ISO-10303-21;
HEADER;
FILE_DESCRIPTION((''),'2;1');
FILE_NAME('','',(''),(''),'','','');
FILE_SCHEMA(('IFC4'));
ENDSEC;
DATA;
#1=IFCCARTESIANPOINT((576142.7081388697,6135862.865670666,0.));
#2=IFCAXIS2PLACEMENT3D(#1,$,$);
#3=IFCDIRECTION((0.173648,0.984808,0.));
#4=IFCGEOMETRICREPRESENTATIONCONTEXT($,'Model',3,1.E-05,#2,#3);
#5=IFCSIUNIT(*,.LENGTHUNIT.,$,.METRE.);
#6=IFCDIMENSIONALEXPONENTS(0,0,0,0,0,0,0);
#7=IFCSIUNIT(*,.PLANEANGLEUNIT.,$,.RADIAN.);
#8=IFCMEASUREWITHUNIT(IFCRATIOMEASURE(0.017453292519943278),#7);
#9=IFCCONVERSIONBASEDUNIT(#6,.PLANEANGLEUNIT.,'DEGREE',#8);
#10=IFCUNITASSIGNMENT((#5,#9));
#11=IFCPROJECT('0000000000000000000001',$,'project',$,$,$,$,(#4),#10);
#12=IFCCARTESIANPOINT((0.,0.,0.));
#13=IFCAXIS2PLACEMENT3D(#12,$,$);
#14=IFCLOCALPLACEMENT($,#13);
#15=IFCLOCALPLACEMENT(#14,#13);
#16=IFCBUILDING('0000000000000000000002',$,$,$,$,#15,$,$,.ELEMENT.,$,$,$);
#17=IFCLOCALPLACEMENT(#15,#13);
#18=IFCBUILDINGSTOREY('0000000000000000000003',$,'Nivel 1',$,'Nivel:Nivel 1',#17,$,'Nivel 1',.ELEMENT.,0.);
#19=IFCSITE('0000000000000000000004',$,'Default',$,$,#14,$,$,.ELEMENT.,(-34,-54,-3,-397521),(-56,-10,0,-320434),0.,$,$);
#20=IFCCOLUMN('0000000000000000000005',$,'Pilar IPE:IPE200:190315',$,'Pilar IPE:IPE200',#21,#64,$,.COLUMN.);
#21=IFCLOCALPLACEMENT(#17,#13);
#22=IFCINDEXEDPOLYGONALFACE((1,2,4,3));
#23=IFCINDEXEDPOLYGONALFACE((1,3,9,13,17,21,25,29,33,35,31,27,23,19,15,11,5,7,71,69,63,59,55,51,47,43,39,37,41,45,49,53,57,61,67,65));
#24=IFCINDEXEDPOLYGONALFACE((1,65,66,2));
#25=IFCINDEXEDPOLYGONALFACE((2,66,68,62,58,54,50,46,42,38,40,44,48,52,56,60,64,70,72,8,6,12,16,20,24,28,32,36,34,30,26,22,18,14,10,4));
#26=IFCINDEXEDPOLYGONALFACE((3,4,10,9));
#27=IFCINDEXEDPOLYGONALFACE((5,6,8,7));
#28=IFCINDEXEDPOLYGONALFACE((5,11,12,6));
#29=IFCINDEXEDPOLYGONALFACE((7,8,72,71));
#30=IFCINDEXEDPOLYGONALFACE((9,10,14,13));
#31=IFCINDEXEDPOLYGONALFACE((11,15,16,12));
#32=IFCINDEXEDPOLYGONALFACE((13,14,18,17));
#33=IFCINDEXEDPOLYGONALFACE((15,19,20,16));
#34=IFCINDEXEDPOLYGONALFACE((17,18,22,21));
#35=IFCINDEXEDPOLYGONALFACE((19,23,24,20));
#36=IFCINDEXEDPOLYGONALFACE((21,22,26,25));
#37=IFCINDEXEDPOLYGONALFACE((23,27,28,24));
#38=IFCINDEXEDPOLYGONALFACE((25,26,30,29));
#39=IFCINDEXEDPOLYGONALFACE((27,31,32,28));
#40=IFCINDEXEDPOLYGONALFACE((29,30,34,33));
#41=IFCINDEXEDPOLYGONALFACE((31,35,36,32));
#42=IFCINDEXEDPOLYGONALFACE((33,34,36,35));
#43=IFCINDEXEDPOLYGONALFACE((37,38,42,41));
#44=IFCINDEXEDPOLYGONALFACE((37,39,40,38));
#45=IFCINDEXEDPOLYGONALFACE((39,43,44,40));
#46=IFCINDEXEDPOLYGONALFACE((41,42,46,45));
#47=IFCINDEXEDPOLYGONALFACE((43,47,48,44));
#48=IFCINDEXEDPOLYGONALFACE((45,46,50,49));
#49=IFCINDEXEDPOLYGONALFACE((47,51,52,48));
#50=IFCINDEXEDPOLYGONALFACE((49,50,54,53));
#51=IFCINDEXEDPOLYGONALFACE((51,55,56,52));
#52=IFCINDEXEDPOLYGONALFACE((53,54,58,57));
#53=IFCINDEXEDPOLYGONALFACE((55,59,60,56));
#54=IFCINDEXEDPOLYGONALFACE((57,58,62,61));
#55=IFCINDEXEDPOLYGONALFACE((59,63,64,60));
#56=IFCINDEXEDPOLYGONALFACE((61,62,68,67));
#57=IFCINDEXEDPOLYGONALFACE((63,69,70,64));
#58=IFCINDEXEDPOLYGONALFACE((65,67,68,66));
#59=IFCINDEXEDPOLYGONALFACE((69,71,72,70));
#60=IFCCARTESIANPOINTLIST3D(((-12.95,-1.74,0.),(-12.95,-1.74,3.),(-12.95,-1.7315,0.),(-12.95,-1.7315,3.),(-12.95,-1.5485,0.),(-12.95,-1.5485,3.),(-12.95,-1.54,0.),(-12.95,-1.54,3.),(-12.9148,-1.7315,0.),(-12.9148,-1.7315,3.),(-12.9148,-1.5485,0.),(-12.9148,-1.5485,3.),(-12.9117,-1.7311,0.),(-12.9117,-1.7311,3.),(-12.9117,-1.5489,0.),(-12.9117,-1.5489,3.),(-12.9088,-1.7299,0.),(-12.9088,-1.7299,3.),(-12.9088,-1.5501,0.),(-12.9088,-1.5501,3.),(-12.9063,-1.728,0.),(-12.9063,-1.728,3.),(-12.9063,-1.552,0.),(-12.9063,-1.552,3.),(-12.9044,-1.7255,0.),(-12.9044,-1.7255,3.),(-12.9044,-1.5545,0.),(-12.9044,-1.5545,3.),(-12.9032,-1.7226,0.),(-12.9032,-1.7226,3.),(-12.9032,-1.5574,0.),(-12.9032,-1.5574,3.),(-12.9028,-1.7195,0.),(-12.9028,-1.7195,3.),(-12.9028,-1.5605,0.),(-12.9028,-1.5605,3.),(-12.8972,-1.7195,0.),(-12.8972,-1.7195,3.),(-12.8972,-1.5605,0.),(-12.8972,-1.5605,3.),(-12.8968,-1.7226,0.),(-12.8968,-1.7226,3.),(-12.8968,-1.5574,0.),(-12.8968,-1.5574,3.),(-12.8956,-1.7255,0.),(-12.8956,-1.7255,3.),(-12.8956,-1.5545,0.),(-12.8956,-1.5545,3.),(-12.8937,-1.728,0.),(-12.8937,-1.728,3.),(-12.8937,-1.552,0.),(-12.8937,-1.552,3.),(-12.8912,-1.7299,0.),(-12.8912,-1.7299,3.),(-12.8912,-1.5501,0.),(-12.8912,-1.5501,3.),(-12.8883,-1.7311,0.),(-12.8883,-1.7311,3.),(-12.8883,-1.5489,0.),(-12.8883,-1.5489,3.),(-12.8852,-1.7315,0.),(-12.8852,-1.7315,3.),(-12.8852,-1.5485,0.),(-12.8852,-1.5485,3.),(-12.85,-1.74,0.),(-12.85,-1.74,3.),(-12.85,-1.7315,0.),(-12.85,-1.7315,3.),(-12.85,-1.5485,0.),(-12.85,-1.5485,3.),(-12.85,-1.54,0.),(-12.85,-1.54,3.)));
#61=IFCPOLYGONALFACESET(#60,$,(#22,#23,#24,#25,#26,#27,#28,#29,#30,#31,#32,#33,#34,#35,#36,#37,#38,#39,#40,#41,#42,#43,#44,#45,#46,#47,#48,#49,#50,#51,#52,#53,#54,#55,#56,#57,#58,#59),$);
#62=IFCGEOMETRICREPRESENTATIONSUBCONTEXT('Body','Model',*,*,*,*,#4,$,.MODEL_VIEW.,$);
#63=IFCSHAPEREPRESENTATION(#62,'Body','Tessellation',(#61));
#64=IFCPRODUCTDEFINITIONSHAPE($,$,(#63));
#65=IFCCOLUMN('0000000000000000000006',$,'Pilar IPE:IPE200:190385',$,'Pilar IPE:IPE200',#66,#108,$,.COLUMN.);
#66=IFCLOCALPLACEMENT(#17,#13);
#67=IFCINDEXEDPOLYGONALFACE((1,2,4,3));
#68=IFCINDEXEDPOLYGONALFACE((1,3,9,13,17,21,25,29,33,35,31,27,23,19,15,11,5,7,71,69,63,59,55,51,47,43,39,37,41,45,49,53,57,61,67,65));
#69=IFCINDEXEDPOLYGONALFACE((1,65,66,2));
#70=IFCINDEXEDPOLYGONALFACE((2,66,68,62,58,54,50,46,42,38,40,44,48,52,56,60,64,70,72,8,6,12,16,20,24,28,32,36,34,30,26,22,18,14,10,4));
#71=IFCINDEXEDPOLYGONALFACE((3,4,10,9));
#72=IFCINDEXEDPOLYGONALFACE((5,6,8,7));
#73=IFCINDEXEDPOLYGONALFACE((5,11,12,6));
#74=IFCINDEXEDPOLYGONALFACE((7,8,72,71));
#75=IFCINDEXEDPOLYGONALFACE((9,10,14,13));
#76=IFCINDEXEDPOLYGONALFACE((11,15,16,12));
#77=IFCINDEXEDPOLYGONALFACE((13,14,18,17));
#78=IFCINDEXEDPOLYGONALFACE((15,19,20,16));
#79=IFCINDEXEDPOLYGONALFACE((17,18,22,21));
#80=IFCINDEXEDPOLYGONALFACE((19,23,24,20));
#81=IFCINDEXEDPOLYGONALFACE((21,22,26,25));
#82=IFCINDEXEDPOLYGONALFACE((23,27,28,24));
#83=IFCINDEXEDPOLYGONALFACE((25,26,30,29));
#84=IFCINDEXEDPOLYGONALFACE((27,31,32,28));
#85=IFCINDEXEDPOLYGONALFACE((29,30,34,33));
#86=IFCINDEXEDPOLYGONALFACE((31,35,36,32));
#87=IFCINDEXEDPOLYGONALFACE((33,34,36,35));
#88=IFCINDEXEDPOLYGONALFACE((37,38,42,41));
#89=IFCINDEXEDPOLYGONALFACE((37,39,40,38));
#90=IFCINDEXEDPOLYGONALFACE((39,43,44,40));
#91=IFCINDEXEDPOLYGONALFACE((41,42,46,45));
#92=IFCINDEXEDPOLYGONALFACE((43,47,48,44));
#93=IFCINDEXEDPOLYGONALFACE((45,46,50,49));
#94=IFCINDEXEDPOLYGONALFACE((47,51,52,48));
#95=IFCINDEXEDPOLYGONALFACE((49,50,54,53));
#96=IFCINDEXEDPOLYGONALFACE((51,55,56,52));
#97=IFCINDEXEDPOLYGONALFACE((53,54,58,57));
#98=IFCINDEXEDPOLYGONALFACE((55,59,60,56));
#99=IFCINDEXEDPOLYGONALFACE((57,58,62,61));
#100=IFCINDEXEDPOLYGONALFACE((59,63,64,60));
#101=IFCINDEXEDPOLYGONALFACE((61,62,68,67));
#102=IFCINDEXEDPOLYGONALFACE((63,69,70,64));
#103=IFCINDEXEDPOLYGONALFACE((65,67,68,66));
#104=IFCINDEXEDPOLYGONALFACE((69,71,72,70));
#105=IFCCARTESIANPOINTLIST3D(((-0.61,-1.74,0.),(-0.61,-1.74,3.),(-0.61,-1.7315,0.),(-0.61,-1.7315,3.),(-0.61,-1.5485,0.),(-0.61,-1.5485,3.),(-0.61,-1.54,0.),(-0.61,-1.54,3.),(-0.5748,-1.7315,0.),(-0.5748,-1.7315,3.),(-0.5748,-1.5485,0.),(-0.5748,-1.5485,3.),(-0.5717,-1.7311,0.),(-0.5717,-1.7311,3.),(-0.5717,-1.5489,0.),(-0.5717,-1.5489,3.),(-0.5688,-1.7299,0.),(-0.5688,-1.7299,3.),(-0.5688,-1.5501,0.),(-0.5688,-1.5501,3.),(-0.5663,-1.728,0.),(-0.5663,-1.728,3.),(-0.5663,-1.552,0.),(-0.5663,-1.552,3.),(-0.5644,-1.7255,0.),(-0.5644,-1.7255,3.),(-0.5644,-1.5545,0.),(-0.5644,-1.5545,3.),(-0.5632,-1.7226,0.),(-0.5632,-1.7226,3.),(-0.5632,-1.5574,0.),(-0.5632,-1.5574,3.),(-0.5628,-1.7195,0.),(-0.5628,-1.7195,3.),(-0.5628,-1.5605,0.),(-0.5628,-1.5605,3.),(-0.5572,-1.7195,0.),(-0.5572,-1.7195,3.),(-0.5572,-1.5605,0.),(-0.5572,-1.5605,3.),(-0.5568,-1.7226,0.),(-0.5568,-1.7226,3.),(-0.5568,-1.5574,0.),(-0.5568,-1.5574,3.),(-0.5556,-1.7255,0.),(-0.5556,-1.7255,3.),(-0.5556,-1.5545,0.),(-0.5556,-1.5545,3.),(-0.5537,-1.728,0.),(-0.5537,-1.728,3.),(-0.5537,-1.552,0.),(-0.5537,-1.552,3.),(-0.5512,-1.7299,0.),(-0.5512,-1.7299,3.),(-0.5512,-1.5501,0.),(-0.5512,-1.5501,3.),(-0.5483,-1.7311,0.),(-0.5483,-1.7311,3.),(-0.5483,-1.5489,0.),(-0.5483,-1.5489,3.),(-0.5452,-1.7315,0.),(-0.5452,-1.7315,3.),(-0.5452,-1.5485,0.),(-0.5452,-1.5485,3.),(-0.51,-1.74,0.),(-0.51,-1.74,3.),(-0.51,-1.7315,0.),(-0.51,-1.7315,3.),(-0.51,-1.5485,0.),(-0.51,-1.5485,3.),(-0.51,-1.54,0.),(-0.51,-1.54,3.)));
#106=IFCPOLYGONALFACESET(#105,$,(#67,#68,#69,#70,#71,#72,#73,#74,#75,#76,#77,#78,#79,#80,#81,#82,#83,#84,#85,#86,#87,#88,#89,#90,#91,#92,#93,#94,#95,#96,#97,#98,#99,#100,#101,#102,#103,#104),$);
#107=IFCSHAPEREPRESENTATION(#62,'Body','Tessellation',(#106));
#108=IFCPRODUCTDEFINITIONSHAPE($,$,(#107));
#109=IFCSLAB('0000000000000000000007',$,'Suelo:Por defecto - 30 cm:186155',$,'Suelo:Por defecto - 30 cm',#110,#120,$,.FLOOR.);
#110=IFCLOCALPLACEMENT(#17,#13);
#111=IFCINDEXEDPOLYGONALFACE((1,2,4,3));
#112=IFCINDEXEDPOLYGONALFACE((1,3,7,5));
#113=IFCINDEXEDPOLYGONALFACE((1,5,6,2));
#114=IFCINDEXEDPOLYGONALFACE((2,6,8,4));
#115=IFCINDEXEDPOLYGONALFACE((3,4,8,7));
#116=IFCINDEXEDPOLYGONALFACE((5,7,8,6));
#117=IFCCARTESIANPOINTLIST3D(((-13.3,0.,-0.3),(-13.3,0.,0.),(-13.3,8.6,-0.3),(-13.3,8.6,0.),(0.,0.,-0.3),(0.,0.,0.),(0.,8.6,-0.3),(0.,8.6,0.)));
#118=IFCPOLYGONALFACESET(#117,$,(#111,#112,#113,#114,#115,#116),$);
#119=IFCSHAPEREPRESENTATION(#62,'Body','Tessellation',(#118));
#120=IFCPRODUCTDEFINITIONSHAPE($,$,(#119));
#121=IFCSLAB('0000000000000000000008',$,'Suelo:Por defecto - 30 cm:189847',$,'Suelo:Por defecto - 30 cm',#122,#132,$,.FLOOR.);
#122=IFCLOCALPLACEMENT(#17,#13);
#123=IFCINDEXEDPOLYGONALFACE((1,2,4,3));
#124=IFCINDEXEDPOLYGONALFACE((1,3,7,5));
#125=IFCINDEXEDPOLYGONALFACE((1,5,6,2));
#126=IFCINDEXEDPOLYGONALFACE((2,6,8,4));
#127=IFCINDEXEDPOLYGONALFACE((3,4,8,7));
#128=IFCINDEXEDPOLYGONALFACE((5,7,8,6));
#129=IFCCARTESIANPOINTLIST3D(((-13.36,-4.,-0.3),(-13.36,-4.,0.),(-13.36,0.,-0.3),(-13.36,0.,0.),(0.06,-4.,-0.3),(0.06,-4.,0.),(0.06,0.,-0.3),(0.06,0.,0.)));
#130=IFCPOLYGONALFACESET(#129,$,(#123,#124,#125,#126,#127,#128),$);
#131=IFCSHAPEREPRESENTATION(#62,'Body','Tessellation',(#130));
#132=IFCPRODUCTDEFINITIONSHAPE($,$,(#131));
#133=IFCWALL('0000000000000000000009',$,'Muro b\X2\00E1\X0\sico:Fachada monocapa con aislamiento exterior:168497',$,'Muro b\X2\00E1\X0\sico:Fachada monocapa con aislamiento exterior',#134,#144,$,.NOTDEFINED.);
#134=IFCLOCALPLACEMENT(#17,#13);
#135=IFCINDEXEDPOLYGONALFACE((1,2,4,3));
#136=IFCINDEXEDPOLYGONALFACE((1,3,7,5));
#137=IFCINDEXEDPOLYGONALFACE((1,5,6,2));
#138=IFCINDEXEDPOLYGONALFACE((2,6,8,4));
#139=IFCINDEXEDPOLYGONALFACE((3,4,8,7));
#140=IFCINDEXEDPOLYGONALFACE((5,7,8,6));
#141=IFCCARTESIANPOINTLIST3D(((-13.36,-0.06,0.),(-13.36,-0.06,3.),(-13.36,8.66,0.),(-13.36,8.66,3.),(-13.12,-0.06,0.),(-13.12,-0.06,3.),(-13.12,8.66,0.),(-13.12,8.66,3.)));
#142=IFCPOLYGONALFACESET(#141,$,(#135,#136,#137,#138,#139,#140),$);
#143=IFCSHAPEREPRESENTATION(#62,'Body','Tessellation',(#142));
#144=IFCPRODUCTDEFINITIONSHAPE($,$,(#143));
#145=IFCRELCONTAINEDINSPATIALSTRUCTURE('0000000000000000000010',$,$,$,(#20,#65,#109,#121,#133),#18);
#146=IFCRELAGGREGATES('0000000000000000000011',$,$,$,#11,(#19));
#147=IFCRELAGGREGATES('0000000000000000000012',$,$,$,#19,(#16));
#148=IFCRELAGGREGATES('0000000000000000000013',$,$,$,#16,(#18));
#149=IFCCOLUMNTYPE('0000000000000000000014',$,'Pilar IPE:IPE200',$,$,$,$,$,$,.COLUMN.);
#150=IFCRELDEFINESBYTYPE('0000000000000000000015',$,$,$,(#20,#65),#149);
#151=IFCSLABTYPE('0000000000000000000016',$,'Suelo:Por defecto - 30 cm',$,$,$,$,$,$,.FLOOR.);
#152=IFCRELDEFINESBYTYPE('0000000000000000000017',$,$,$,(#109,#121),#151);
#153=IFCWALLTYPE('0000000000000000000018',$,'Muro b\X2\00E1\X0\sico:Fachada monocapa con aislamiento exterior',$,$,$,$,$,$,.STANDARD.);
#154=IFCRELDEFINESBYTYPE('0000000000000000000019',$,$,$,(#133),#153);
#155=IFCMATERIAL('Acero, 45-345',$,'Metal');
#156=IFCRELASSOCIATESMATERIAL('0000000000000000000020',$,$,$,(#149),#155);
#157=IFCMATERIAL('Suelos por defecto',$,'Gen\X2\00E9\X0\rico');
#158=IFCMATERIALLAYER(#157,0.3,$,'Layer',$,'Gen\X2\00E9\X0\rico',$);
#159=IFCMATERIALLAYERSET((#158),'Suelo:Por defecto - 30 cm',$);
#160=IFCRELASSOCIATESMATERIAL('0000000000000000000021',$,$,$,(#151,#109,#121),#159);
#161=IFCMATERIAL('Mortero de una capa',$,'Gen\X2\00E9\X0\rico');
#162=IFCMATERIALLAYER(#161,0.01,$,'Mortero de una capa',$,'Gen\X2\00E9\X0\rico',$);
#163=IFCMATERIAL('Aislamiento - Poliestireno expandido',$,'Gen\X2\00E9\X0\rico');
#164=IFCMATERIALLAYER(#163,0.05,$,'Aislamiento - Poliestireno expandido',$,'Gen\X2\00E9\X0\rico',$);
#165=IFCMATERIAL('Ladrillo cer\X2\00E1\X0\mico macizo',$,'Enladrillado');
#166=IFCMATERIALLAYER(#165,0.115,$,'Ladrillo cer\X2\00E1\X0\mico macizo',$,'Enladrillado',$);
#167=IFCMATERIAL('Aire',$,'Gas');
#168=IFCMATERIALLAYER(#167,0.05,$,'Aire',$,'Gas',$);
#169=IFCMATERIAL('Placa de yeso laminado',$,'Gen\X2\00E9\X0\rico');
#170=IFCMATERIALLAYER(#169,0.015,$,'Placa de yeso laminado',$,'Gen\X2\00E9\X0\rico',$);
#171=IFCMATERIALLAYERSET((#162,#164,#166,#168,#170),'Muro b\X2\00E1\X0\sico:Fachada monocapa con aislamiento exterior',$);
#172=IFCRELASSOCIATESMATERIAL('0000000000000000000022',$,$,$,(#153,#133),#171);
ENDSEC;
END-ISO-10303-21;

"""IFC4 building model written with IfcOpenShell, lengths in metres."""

from ifc_helpers import new_model, entity, si_unit, converted_unit, direction, frame, frame_2d, origin, place, context, subcontext, project, spatial, rectangle, i_section, extrude, source, transform, mapped, material, layer, layer_set, layer_usage, material_profile, profile_set, type_object, type_shapes, element, save


model = new_model("IFC4")

# Units and contexts
model_context = context("Model", 3, precision=1e-05, world=frame((576142.7081388697, 6135862.865670666, 0.0)), true_north=direction((0.173648, 0.984808, 0.0)))
body_context = subcontext(model_context, "Body", "Model", "MODEL_VIEW")
ifc_project = project(units=[si_unit("LENGTHUNIT", "METRE"), converted_unit("PLANEANGLEUNIT", "DEGREE", entity("IfcRatioMeasure", 0.017453292519943278), si_unit("PLANEANGLEUNIT", "RADIAN"), dimensions=[0, 0, 0, 0, 0, 0, 0])], contexts=[model_context])

# Site, building, storey
site_placement = place(None, origin())
site = spatial("IfcSite", under=ifc_project, at=site_placement, Name="Default", CompositionType="ELEMENT", RefLatitude=(-34, -54, -3, -397521), RefLongitude=(-56, -10, 0, -320434), RefElevation=0.0)
building_placement = place(site_placement, origin())
building = spatial("IfcBuilding", under=site, at=building_placement, CompositionType="ELEMENT")
storey_placement = place(building_placement, origin())
storey = spatial("IfcBuildingStorey", under=building, at=storey_placement, Name="Nivel 1", ObjectType="Nivel:Nivel 1", LongName="Nivel 1", CompositionType="ELEMENT", Elevation=0.0)

# Columns
ifc_material_1 = material(Name="Acero, 45-345", Category="Metal")
ifc_material_profile = material_profile(ifc_material_1, i_section(OverallWidth=0.1, OverallDepth=0.2, WebThickness=0.0056, FlangeThickness=0.0085, FilletRadius=0.012, at=frame_2d((0.0, 0.0), x_axis=(0.0, 1.0))), Name="IPE200")
ifc_profile_set = profile_set([ifc_material_profile], Name="IPE200")
column_type = type_object("IfcColumnType", Name="Pilar IPE:IPE200", PredefinedType="COLUMN", material=ifc_profile_set)
shared_shape_1 = source(origin(), body_context, "Body", "SweptSolid", [
    extrude(i_section(OverallWidth=0.1, OverallDepth=0.2, WebThickness=0.0056, FlangeThickness=0.0085, FilletRadius=0.012, at=frame_2d((0.0, 0.0), x_axis=(0.0, 1.0))), frame((0.0, 0.0, 0.0), z_axis=(0.0, 0.0, 1.0), x_axis=(0.0, -1.0, 0.0)), (0.0, 0.0, 1.0), 3.0),
])
type_shapes(column_type, [shared_shape_1])
for number, where, name in (
    (1, (-12.9, -1.64, 0.0), "Pilar IPE:IPE200:190315"),
    (2, (-0.56, -1.64, 0.0), "Pilar IPE:IPE200:190385"),
):
    element("IfcColumn", number, at=place(storey_placement, frame(where)), inside=storey, type_object=column_type, Name=name, ObjectType="Pilar IPE:IPE200", PredefinedType="COLUMN", context=body_context, shape_type="MappedRepresentation", body=[
        mapped(shared_shape_1, transform((0.0, 0.0, 0.0), scale=1.0)),
    ])

# Slabs
ifc_material_2 = material(Name="Suelos por defecto", Category="Genérico")
ifc_layer_1 = layer(ifc_material_2, 0.3, Name="Layer", Category="Genérico")
ifc_layer_set_1 = layer_set([ifc_layer_1], Name="Suelo:Por defecto - 30 cm")
ifc_layer_usage_1 = layer_usage(ifc_layer_set_1, "AXIS3", "POSITIVE", 0.0)
slab_type = type_object("IfcSlabType", Name="Suelo:Por defecto - 30 cm", PredefinedType="FLOOR", material=ifc_layer_set_1)
slab_1_placement = place(storey_placement, origin())
element("IfcSlab", 3, at=slab_1_placement, inside=storey, type_object=slab_type, material=ifc_layer_usage_1, Name="Suelo:Por defecto - 30 cm:186155", ObjectType="Suelo:Por defecto - 30 cm", PredefinedType="FLOOR", context=body_context, shape_type="SweptSolid", body=[
    extrude(rectangle(XDim=8.6, YDim=13.3, at=frame_2d((0.0, 0.0), x_axis=(1.0, 0.0))), frame((-6.65, 4.3, 0.0), z_axis=(0.0, 0.0, -1.0), x_axis=(0.0, 1.0, 0.0)), (0.0, 0.0, 1.0), 0.3),
])
slab_2_placement = place(storey_placement, origin())
element("IfcSlab", 4, at=slab_2_placement, inside=storey, type_object=slab_type, material=ifc_layer_usage_1, Name="Suelo:Por defecto - 30 cm:189847", ObjectType="Suelo:Por defecto - 30 cm", PredefinedType="FLOOR", context=body_context, shape_type="SweptSolid", body=[
    extrude(rectangle(XDim=4.0, YDim=13.42, at=frame_2d((0.0, 0.0), x_axis=(1.0, 0.0))), frame((-6.65, -2.0, 0.0), z_axis=(0.0, 0.0, -1.0), x_axis=(0.0, 1.0, 0.0)), (0.0, 0.0, 1.0), 0.3),
])

# Wall
ifc_material_3 = material(Name="Mortero de una capa", Category="Genérico")
ifc_layer_2 = layer(ifc_material_3, 0.01, Name="Mortero de una capa", Category="Genérico")
ifc_material_4 = material(Name="Aislamiento - Poliestireno expandido", Category="Genérico")
ifc_layer_3 = layer(ifc_material_4, 0.05, Name="Aislamiento - Poliestireno expandido", Category="Genérico")
ifc_material_5 = material(Name="Ladrillo cerámico macizo", Category="Enladrillado")
ifc_layer_4 = layer(ifc_material_5, 0.115, Name="Ladrillo cerámico macizo", Category="Enladrillado")
ifc_material_6 = material(Name="Aire", Category="Gas")
ifc_layer_5 = layer(ifc_material_6, 0.05, Name="Aire", Category="Gas")
ifc_material_7 = material(Name="Placa de yeso laminado", Category="Genérico")
ifc_layer_6 = layer(ifc_material_7, 0.015, Name="Placa de yeso laminado", Category="Genérico")
ifc_layer_set_2 = layer_set([ifc_layer_2, ifc_layer_3, ifc_layer_4, ifc_layer_5, ifc_layer_6], Name="Muro básico:Fachada monocapa con aislamiento exterior")
ifc_layer_usage_2 = layer_usage(ifc_layer_set_2, "AXIS2", "NEGATIVE", 0.12)
wall_type_1 = type_object("IfcWallType", Name="Muro básico:Fachada monocapa con aislamiento exterior", PredefinedType="STANDARD", material=ifc_layer_set_2)
wall_1_placement = place(storey_placement, frame((-13.24, -0.06, 0.0), z_axis=(0.0, 0.0, 1.0), x_axis=(0.0, 1.0, 0.0)))
element("IfcWall", 5, at=wall_1_placement, inside=storey, type_object=wall_type_1, material=ifc_layer_usage_2, Name="Muro básico:Fachada monocapa con aislamiento exterior:168497", ObjectType="Muro básico:Fachada monocapa con aislamiento exterior", PredefinedType="NOTDEFINED", context=body_context, shape_type="SweptSolid", body=[
    extrude(rectangle(XDim=8.72, YDim=0.24, at=frame_2d((4.36, 0.0), x_axis=(-1.0, 0.0))), origin(), (0.0, 0.0, 1.0), 3.0),
])

save(model, "model.ifc")
